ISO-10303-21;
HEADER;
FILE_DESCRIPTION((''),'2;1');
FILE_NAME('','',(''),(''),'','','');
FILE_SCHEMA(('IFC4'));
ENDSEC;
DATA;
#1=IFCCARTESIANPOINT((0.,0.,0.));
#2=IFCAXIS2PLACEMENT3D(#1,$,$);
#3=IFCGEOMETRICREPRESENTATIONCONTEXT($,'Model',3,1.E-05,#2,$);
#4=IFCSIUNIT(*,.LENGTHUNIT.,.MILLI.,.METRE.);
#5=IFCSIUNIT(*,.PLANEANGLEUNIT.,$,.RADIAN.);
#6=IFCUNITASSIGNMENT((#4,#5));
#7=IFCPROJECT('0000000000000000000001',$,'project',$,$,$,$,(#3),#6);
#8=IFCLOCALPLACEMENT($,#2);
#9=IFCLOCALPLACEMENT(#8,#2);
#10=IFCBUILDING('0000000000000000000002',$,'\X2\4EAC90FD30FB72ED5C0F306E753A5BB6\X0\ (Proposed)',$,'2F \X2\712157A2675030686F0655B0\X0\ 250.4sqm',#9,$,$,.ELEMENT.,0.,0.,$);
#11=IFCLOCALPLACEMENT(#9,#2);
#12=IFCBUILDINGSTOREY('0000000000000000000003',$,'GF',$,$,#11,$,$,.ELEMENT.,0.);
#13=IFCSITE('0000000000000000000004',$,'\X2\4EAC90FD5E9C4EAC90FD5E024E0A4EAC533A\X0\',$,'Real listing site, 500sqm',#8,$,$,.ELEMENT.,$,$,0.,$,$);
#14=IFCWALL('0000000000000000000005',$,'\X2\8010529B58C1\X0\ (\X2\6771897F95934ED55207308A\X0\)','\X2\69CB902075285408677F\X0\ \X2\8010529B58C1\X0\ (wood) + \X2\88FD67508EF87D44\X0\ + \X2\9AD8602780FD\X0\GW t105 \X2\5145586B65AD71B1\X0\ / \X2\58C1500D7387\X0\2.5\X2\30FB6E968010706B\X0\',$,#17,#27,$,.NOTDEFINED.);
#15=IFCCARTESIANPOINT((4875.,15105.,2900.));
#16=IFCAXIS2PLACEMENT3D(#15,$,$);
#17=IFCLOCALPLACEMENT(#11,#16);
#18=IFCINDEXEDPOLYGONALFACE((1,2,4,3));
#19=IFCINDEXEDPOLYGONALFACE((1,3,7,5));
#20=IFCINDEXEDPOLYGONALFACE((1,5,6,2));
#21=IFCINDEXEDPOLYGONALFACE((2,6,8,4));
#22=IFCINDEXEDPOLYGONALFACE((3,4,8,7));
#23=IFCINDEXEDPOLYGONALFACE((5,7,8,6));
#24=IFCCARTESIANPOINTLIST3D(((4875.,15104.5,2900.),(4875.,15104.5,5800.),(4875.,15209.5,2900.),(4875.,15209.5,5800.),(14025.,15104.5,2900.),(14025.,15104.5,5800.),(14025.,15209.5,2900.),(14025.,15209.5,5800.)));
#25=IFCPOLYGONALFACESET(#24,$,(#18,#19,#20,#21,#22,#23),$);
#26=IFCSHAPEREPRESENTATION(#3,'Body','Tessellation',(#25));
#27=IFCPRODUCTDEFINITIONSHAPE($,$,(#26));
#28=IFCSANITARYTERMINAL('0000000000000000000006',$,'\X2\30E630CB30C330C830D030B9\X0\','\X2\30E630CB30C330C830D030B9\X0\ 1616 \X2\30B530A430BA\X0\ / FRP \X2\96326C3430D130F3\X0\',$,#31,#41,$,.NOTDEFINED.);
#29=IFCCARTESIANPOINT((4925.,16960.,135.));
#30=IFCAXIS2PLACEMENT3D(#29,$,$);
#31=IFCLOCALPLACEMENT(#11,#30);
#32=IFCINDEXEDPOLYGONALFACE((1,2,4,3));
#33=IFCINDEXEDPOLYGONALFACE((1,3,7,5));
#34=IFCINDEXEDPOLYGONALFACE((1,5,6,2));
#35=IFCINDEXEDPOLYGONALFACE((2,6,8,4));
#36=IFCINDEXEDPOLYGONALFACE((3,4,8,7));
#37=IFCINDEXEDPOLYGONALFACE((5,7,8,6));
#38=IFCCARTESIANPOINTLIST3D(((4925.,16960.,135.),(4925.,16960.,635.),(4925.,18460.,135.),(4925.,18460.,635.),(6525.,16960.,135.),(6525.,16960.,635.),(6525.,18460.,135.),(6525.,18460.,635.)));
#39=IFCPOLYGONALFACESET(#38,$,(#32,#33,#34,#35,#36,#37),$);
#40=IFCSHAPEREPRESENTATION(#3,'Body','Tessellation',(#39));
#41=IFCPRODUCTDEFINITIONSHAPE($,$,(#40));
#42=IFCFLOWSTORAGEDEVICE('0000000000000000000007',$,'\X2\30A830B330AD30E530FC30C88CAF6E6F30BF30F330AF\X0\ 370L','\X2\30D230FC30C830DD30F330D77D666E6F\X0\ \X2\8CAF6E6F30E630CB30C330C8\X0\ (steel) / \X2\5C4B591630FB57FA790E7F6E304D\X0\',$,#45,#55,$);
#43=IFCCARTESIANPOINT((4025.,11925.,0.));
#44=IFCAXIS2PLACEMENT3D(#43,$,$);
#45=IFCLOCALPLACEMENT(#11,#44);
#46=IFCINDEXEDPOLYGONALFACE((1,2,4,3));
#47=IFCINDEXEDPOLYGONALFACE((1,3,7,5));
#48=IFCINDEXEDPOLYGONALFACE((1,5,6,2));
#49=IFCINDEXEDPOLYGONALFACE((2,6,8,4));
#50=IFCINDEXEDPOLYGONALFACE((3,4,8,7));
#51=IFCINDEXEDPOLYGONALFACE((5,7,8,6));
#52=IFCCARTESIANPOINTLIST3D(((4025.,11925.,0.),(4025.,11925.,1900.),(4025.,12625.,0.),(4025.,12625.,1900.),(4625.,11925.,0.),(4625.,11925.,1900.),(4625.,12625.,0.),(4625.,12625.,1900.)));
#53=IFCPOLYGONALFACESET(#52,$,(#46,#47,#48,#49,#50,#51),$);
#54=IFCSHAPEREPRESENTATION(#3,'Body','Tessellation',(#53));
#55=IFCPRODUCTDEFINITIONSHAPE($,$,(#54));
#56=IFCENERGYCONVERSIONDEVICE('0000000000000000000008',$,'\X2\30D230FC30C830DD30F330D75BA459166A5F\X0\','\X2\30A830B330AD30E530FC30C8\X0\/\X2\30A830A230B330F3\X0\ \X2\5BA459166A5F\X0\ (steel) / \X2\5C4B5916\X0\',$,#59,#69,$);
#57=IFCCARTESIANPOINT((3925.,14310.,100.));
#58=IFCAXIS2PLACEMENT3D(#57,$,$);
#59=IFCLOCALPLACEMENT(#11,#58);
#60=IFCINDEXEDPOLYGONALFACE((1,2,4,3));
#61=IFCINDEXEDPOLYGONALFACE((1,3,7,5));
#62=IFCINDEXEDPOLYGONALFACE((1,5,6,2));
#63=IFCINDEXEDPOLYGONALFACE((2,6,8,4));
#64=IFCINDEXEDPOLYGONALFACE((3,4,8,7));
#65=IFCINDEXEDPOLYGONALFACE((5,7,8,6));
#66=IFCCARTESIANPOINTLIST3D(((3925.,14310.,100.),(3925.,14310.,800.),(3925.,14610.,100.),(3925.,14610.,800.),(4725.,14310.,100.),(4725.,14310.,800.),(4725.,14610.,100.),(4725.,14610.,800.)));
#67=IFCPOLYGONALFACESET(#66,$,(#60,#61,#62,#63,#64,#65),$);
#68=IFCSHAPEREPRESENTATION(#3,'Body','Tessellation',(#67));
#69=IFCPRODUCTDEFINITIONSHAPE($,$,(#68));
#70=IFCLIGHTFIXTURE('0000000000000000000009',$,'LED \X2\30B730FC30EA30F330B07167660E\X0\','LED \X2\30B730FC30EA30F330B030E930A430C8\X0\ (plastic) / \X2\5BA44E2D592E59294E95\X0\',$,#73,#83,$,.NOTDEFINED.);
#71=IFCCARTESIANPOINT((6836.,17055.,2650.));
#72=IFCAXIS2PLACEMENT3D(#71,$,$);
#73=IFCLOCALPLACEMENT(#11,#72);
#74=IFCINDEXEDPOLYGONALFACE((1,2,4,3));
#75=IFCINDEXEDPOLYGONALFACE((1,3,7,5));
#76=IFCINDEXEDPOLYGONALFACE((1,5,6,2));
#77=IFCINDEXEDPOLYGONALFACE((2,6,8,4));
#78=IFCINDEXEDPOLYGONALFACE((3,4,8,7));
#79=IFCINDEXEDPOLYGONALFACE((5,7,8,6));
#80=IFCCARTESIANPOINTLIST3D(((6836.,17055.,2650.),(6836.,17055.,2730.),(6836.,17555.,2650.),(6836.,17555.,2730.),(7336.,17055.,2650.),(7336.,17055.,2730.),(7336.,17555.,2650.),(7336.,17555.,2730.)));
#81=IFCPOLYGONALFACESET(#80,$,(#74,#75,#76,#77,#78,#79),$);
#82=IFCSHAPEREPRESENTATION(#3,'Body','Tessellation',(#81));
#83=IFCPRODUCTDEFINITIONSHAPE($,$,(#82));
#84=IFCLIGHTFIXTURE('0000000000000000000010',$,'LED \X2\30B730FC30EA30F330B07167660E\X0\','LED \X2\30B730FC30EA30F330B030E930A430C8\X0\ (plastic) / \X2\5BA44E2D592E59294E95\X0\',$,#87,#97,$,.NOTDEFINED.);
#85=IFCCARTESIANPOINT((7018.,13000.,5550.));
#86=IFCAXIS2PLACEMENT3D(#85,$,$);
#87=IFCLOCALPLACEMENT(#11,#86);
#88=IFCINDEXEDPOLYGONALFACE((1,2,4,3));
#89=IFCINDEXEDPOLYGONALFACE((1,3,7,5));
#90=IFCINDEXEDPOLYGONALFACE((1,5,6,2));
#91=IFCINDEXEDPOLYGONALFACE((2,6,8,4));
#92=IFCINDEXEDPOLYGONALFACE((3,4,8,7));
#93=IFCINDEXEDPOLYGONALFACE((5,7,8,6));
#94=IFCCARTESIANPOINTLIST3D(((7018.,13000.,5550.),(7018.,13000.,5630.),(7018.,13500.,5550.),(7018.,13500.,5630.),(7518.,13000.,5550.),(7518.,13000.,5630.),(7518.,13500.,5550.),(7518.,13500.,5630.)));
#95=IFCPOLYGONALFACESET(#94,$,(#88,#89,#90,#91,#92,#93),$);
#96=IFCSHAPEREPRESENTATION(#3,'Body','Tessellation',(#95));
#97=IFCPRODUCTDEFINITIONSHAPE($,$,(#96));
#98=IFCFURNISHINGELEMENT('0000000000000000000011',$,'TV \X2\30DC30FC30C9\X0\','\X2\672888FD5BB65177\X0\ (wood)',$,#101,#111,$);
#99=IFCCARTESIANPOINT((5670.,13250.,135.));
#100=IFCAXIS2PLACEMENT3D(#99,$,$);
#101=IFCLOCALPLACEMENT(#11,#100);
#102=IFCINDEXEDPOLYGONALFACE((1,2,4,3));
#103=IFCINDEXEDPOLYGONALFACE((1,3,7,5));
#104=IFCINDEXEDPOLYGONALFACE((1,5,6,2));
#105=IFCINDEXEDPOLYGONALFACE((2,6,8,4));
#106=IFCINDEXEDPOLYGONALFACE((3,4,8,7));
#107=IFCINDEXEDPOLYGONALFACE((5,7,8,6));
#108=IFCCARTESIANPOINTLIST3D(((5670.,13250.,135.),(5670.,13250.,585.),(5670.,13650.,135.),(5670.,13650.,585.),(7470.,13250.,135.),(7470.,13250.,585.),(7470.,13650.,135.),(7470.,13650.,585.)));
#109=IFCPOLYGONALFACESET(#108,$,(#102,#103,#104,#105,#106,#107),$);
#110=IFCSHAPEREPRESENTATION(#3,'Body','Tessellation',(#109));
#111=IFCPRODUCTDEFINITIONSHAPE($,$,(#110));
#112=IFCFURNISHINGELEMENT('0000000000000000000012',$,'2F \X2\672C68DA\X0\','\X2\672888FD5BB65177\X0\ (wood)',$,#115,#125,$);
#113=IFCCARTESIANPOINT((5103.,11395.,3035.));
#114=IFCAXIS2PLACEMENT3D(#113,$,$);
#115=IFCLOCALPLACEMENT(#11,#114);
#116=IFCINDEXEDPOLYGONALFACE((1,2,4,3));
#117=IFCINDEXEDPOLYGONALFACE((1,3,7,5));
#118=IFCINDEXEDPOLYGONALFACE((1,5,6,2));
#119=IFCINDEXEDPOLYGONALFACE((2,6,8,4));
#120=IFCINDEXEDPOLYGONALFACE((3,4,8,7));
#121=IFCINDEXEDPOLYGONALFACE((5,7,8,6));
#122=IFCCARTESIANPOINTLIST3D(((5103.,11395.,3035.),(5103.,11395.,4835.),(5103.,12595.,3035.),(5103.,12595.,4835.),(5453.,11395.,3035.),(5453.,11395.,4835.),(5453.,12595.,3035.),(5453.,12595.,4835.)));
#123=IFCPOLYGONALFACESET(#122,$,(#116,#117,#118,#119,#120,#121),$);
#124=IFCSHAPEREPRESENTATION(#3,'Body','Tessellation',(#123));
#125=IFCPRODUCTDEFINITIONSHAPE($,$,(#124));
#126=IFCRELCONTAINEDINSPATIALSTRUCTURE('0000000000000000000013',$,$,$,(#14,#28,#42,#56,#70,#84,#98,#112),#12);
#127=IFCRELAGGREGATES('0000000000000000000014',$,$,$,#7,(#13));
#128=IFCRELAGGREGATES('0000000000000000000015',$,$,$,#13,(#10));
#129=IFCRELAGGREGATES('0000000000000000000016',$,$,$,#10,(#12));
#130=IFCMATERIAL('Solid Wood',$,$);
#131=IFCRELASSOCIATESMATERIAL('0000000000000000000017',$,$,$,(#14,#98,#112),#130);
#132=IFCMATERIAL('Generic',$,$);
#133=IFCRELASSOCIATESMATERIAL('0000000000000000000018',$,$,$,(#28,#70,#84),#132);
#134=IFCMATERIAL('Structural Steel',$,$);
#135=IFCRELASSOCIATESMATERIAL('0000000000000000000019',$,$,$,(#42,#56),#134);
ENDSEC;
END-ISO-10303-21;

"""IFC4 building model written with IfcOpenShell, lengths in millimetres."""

from ifc_helpers import new_model, si_unit, frame, frame_2d, origin, place, context, project, spatial, rectangle, extrude, material, element, save


model = new_model("IFC4")

# Units and contexts
model_context = context("Model", 3, precision=1e-05, world=origin())
ifc_project = project(units=[si_unit("LENGTHUNIT", "METRE", prefix="MILLI"), si_unit("PLANEANGLEUNIT", "RADIAN")], contexts=[model_context])

# Site, building, storey
site_placement = place(None, origin())
site = spatial("IfcSite", under=ifc_project, at=site_placement, Name="京都府京都市上京区", ObjectType="Real listing site, 500sqm", CompositionType="ELEMENT", RefElevation=0.0)
building_placement = place(site_placement, origin())
building = spatial("IfcBuilding", under=site, at=building_placement, Name="京都・狭小の町家 (Proposed)", ObjectType="2F 無垢材と漆喰 250.4sqm", CompositionType="ELEMENT", ElevationOfRefHeight=0.0, ElevationOfTerrain=0.0)
storey_placement = place(building_placement, origin())
storey = spatial("IfcBuildingStorey", under=building, at=storey_placement, Name="GF", CompositionType="ELEMENT", Elevation=0.0)

# Shared definitions
ifc_material_1 = material(Name="Solid Wood")

# Wall
wall_1_placement = place(storey_placement, frame((4875.0, 15105.0, 2900.0)))
element("IfcWall", 1, at=wall_1_placement, inside=storey, material=ifc_material_1, Name="耐力壁 (東西間仕切り)", Description="構造用合板 耐力壁 (wood) + 製材軸組 + 高性能GW t105 充填断熱 / 壁倍率2.5・準耐火", PredefinedType="NOTDEFINED", context=model_context, shape_type="SweptSolid", body=[
    extrude(rectangle(XDim=9150.0, YDim=105.0, at=frame_2d((4575.0, 52.0))), frame((4875.0, 15105.0, 2900.0)), (0.0, 0.0, 1.0), 2900.0),
])

# Sanitary terminal
ifc_material_2 = material(Name="Generic")
sanitary_terminal_placement = place(storey_placement, frame((4925.0, 16960.0, 135.0)))
element("IfcSanitaryTerminal", 2, at=sanitary_terminal_placement, inside=storey, material=ifc_material_2, Name="ユニットバス", Description="ユニットバス 1616 サイズ / FRP 防水パン", PredefinedType="NOTDEFINED", context=model_context, shape_type="SweptSolid", body=[
    extrude(rectangle(XDim=1600.0, YDim=1500.0, at=frame_2d((800.0, 750.0))), frame((4925.0, 16960.0, 135.0)), (0.0, 0.0, 1.0), 500.0),
])

# Flow storage device
ifc_material_3 = material(Name="Structural Steel")
flow_storage_device_placement = place(storey_placement, frame((4025.0, 11925.0, 0.0)))
element("IfcFlowStorageDevice", 3, at=flow_storage_device_placement, inside=storey, material=ifc_material_3, Name="エコキュート貯湯タンク 370L", Description="ヒートポンプ給湯 貯湯ユニット (steel) / 屋外・基礎置き", context=model_context, shape_type="SweptSolid", body=[
    extrude(rectangle(XDim=600.0, YDim=700.0, at=frame_2d((300.0, 350.0))), frame((4025.0, 11925.0, 0.0)), (0.0, 0.0, 1.0), 1900.0),
])

# Energy conversion device
energy_conversion_device_placement = place(storey_placement, frame((3925.0, 14310.0, 100.0)))
element("IfcEnergyConversionDevice", 4, at=energy_conversion_device_placement, inside=storey, material=ifc_material_3, Name="ヒートポンプ室外機", Description="エコキュート/エアコン 室外機 (steel) / 屋外", context=model_context, shape_type="SweptSolid", body=[
    extrude(rectangle(XDim=800.0, YDim=300.0, at=frame_2d((400.0, 150.0))), frame((3925.0, 14310.0, 100.0)), (0.0, 0.0, 1.0), 700.0),
])

# Light fixtures
light_fixture_1_placement = place(storey_placement, frame((6836.0, 17055.0, 2650.0)))
element("IfcLightFixture", 5, at=light_fixture_1_placement, inside=storey, material=ifc_material_2, Name="LED シーリング照明", Description="LED シーリングライト (plastic) / 室中央天井", PredefinedType="NOTDEFINED", context=model_context, shape_type="SweptSolid", body=[
    extrude(rectangle(XDim=500.0, YDim=500.0, at=frame_2d((250.0, 250.0))), frame((6836.0, 17055.0, 2650.0)), (0.0, 0.0, 1.0), 80.0),
])
light_fixture_2_placement = place(storey_placement, frame((7018.0, 13000.0, 5550.0)))
element("IfcLightFixture", 6, at=light_fixture_2_placement, inside=storey, material=ifc_material_2, Name="LED シーリング照明", Description="LED シーリングライト (plastic) / 室中央天井", PredefinedType="NOTDEFINED", context=model_context, shape_type="SweptSolid", body=[
    extrude(rectangle(XDim=500.0, YDim=500.0, at=frame_2d((250.0, 250.0))), frame((7018.0, 13000.0, 5550.0)), (0.0, 0.0, 1.0), 80.0),
])

# Furnishing elements
furnishing_1_placement = place(storey_placement, frame((5670.0, 13250.0, 135.0)))
element("IfcFurnishingElement", 7, at=furnishing_1_placement, inside=storey, material=ifc_material_1, Name="TV ボード", Description="木製家具 (wood)", context=model_context, shape_type="SweptSolid", body=[
    extrude(rectangle(XDim=1800.0, YDim=400.0, at=frame_2d((900.0, 200.0))), frame((5670.0, 13250.0, 135.0)), (0.0, 0.0, 1.0), 450.0),
])
furnishing_2_placement = place(storey_placement, frame((5103.0, 11395.0, 3035.0)))
element("IfcFurnishingElement", 8, at=furnishing_2_placement, inside=storey, material=ifc_material_1, Name="2F 本棚", Description="木製家具 (wood)", context=model_context, shape_type="SweptSolid", body=[
    extrude(rectangle(XDim=350.0, YDim=1200.0, at=frame_2d((175.0, 600.0))), frame((5103.0, 11395.0, 3035.0)), (0.0, 0.0, 1.0), 1800.0),
])

save(model, "model.ifc")
